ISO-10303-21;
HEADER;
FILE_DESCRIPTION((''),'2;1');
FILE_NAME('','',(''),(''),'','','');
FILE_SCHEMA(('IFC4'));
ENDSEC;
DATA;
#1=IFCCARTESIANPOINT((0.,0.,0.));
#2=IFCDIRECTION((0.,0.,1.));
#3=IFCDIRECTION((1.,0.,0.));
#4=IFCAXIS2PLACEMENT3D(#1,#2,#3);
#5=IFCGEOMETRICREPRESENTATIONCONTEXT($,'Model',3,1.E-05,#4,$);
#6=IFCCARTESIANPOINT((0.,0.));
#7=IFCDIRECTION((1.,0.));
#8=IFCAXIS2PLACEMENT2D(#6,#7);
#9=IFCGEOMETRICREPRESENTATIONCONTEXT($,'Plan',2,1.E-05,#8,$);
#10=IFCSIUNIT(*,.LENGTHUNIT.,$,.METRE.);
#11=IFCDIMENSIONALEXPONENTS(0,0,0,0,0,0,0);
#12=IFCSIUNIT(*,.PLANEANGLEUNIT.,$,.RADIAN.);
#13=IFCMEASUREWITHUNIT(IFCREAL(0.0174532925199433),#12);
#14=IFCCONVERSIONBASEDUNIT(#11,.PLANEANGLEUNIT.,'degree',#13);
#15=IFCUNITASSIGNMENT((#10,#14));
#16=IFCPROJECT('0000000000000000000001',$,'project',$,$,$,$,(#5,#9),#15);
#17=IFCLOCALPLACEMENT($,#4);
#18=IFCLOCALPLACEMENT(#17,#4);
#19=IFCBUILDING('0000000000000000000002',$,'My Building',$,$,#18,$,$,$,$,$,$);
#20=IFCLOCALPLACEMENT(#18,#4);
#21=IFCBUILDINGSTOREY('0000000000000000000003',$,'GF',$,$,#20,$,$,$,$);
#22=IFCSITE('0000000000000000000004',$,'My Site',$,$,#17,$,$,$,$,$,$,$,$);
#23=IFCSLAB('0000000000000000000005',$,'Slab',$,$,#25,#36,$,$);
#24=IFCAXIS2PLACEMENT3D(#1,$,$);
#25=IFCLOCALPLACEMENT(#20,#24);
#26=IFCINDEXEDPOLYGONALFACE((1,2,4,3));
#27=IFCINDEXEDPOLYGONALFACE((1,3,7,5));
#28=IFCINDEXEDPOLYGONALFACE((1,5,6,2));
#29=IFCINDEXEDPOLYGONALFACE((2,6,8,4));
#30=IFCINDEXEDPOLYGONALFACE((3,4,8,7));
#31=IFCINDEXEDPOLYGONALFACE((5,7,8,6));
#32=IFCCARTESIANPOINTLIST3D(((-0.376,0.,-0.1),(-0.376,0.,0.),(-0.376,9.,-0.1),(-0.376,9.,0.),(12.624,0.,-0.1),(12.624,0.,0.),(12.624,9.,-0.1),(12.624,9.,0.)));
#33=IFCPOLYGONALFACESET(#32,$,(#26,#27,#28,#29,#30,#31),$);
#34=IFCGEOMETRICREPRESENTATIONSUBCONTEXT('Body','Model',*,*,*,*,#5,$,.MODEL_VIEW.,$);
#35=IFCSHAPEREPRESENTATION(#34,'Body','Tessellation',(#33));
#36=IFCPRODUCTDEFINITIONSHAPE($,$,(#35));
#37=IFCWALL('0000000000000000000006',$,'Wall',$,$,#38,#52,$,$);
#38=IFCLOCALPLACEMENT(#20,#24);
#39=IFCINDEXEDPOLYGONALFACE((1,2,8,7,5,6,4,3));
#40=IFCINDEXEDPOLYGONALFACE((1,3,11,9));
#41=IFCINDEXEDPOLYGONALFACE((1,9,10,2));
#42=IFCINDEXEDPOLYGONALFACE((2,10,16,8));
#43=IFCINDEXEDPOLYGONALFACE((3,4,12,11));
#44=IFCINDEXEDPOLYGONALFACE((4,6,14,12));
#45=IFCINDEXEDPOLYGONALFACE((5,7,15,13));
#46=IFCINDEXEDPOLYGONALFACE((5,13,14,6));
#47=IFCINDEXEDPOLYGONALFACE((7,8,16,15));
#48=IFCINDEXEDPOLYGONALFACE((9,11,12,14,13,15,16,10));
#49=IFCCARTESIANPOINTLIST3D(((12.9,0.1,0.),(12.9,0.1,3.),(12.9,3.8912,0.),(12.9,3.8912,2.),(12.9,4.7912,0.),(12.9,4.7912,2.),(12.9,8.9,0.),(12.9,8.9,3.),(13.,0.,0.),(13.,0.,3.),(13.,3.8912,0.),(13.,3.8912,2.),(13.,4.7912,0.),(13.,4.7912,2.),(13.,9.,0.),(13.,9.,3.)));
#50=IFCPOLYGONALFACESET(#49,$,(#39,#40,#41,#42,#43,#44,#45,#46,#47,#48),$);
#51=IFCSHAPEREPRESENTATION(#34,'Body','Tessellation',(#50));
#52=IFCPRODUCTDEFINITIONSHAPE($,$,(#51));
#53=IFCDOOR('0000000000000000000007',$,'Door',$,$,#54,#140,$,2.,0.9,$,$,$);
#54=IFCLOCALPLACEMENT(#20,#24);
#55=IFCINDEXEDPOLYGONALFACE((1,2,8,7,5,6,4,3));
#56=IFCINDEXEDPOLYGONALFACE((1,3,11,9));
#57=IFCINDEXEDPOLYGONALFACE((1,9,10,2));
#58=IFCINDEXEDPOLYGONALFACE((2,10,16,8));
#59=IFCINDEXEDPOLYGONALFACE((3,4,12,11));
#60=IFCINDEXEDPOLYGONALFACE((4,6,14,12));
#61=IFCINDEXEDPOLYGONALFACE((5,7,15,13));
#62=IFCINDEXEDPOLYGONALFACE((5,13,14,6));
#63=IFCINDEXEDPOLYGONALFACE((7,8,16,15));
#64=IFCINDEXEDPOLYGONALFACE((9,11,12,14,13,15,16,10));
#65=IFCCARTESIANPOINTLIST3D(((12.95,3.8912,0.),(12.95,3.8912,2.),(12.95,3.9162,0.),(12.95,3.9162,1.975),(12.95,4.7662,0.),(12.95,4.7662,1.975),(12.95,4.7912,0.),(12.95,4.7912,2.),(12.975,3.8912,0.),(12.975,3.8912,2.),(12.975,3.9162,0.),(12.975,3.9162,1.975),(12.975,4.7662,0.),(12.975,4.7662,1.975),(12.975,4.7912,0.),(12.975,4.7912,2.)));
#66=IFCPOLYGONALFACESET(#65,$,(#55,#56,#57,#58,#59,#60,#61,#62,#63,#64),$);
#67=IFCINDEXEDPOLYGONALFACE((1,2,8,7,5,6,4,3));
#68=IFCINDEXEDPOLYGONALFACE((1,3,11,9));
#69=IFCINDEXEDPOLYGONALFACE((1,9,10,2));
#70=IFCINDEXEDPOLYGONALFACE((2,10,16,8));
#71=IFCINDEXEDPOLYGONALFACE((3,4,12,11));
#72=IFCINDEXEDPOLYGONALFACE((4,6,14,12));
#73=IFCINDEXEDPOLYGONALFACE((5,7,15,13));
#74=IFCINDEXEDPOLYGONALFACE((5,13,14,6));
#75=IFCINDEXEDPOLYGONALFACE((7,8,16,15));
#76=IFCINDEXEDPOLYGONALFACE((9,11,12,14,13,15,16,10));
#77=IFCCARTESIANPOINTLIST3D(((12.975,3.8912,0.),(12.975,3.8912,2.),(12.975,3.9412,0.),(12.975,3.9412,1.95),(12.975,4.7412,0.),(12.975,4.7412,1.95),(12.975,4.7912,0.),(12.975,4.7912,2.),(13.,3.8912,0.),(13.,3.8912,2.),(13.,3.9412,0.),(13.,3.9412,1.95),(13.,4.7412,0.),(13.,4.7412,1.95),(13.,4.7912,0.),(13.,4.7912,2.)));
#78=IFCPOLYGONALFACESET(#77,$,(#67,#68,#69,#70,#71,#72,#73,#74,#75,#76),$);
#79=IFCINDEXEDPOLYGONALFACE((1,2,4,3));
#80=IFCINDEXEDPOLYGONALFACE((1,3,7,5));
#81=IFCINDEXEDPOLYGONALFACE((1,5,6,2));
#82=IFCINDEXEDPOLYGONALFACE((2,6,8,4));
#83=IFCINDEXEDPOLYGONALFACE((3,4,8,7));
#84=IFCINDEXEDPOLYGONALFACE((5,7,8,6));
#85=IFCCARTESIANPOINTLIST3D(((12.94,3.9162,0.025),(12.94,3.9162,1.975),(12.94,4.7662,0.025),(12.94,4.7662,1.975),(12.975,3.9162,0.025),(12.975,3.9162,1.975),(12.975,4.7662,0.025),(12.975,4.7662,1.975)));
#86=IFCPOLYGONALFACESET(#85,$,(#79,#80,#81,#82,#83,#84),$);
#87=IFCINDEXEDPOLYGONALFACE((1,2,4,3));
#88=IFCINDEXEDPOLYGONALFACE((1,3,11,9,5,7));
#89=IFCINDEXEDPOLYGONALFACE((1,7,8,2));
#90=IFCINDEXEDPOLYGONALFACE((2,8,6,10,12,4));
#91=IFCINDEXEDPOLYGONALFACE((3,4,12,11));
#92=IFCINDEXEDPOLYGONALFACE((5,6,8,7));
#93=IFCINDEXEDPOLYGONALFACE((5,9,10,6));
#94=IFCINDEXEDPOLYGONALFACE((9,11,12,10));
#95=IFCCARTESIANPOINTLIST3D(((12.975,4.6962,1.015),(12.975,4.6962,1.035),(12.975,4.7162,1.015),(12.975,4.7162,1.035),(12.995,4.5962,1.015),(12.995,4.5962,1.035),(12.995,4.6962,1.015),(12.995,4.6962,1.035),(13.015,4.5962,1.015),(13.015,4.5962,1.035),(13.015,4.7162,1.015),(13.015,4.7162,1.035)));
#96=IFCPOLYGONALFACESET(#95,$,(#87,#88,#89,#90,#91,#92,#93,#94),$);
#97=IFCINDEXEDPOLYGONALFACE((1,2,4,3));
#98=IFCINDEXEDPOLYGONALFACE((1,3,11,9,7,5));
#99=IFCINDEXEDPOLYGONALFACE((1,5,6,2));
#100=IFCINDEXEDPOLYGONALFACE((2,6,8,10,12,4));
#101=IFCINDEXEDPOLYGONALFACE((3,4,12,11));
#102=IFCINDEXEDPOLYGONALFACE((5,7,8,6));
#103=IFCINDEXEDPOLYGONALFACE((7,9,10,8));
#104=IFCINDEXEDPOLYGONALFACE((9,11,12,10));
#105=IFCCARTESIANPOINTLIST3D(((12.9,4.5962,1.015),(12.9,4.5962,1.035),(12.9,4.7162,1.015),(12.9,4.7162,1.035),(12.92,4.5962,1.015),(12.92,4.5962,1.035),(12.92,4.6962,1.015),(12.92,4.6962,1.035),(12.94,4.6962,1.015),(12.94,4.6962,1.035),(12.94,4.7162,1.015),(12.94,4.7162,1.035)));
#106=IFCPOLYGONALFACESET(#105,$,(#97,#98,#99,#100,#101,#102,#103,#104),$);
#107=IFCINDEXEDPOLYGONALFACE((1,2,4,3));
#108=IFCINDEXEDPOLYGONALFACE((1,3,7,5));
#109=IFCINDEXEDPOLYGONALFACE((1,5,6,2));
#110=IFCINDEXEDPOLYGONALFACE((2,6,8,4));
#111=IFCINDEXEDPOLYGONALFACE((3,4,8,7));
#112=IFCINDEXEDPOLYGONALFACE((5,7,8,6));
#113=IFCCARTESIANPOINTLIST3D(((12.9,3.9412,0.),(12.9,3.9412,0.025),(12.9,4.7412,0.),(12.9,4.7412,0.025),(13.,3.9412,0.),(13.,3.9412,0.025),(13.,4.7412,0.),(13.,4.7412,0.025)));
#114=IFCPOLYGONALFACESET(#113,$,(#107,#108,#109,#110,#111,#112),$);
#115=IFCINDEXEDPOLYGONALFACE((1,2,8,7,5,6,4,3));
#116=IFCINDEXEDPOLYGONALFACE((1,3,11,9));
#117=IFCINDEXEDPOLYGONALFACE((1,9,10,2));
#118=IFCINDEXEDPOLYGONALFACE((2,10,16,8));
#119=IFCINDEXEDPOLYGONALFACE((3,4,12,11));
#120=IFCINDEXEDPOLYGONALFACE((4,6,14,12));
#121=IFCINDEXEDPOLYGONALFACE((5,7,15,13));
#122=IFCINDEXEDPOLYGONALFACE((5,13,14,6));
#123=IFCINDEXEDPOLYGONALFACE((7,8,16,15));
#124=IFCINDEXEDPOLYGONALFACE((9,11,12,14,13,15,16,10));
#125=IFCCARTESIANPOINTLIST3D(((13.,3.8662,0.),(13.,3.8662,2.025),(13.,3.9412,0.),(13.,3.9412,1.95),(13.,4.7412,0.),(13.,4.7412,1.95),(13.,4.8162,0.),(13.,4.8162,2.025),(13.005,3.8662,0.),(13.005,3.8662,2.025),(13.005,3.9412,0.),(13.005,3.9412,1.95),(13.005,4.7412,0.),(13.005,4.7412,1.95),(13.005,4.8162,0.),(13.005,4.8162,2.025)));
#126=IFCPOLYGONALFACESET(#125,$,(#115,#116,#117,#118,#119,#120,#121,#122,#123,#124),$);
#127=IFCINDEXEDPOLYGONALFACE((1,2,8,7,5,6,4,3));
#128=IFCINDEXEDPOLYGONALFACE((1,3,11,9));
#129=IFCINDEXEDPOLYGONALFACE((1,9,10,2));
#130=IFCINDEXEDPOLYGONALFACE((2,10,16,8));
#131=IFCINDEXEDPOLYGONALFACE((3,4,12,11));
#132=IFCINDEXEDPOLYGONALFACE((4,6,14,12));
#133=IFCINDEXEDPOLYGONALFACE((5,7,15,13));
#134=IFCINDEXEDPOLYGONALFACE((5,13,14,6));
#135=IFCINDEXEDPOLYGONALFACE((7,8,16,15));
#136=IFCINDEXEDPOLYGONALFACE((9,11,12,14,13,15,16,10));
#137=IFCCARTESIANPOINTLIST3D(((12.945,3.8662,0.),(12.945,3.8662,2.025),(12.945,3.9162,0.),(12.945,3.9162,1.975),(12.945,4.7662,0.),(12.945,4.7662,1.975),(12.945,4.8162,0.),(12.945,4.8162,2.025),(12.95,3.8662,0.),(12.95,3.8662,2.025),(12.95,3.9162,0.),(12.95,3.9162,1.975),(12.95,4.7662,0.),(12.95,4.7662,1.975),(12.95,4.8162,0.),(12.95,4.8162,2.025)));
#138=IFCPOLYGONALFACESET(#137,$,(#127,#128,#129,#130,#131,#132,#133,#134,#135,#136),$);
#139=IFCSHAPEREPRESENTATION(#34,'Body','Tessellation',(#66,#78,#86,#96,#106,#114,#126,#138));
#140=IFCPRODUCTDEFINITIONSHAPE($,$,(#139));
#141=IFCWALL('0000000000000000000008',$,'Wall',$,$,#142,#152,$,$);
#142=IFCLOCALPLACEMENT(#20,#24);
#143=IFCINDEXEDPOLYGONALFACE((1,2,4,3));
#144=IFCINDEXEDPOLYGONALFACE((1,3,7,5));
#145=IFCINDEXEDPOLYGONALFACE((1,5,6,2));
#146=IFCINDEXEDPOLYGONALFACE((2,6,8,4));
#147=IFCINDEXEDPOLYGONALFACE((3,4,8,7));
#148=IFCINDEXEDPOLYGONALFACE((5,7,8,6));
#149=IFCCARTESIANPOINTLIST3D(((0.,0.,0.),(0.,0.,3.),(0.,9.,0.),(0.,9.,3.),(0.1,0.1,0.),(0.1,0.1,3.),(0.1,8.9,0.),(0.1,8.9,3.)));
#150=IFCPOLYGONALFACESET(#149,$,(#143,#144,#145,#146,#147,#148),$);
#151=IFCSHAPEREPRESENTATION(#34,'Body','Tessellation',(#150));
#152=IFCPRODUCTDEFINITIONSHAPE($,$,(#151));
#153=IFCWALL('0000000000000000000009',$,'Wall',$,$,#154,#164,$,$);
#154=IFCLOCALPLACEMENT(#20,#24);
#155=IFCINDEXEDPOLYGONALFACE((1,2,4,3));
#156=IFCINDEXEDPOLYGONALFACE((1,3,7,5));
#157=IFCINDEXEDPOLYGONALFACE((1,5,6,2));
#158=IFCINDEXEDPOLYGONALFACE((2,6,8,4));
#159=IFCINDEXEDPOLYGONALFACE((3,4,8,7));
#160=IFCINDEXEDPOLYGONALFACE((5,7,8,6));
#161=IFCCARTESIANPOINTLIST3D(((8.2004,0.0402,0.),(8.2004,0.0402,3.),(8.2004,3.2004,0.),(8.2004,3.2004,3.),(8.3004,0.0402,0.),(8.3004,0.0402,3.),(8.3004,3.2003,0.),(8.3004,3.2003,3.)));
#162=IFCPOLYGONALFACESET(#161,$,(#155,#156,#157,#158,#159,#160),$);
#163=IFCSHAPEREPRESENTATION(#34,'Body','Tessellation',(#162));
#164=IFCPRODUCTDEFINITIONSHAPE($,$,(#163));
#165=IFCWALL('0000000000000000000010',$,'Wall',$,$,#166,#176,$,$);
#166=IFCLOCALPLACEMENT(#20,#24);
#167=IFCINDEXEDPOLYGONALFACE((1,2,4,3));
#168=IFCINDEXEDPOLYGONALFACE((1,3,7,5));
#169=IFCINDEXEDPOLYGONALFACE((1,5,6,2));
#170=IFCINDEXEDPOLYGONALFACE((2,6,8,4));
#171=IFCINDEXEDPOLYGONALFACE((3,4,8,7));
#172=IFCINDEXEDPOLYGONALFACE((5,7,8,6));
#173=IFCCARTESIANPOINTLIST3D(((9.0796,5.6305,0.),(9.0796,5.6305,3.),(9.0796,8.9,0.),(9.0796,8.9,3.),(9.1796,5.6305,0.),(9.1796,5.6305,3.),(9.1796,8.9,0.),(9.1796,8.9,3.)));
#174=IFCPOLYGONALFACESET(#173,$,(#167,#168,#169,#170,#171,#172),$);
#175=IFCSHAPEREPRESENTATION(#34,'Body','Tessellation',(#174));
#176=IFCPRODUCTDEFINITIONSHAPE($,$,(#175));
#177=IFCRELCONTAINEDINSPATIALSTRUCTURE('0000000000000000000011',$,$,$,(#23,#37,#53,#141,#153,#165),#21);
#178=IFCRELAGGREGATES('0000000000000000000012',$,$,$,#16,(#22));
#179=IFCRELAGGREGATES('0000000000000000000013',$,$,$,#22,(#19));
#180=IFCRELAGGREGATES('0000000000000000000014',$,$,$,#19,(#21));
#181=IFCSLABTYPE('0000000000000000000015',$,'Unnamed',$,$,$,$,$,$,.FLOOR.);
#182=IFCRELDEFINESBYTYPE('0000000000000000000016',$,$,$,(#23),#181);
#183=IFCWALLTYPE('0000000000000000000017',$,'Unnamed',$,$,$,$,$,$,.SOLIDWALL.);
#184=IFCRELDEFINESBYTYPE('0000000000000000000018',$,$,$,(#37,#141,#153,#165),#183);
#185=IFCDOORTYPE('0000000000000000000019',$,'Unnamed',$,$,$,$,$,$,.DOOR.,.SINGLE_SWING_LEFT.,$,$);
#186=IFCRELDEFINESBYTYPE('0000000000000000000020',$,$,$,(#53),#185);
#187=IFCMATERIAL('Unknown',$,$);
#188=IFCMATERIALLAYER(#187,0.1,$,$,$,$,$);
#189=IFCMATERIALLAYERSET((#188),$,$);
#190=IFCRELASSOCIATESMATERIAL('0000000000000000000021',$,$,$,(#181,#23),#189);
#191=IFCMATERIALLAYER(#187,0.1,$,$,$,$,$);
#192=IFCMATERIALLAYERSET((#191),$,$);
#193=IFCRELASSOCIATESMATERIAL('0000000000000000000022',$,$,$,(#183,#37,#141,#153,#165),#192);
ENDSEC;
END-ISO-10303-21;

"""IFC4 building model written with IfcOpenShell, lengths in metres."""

from ifc_helpers import new_model, entity, si_unit, converted_unit, frame, origin_with_axes, origin_2d_with_axis, place, context, subcontext, project, spatial, line, indexed_curve, outline, extrude, shape, source, transform, mapped, material, layer, layer_set, layer_usage, type_object, type_shapes, element, fill, save


model = new_model("IFC4")

# Units and contexts
model_context = context("Model", 3, precision=1e-05, world=origin_with_axes())
plan_context = context("Plan", 2, precision=1e-05, world=origin_2d_with_axis())
body_context_1 = subcontext(model_context, "Body", "Model", "MODEL_VIEW")
body_context_2 = subcontext(plan_context, "Body", "Plan", "PLAN_VIEW")
ifc_project = project(units=[si_unit("LENGTHUNIT", "METRE"), converted_unit("PLANEANGLEUNIT", "degree", entity("IfcReal", 0.0174532925199433), si_unit("PLANEANGLEUNIT", "RADIAN"), dimensions=[0, 0, 0, 0, 0, 0, 0])], contexts=[model_context, plan_context])

# Site, building, storey
site_placement = place(None, origin_with_axes())
site = spatial("IfcSite", under=ifc_project, at=site_placement, Name="My Site")
building_placement = place(site_placement, origin_with_axes())
building = spatial("IfcBuilding", under=site, at=building_placement, Name="My Building")
storey_placement = place(building_placement, origin_with_axes())
storey = spatial("IfcBuildingStorey", under=building, at=storey_placement, Name="GF")

# Slab
ifc_material = material(Name="Unknown")
ifc_layer_1 = layer(ifc_material, 0.1)
ifc_layer_set_1 = layer_set([ifc_layer_1])
ifc_layer_usage_1 = layer_usage(ifc_layer_set_1, "AXIS3", "POSITIVE", -0.1)
slab_type = type_object("IfcSlabType", Name="Unnamed", PredefinedType="FLOOR", material=ifc_layer_set_1)
slab_placement = place(storey_placement, frame((-0.376, 9.0, 0.0), z_axis=(0.0, 0.0, 1.0), x_axis=(1.0, 0.0, 0.0)))
element("IfcSlab", 1, at=slab_placement, inside=storey, type_object=slab_type, material=ifc_layer_usage_1, Name="Slab", context=body_context_1, shape_type="SweptSolid", body=[
    extrude(outline(indexed_curve([(0.0, -9.0), (13.0, -9.0), (13.0, 0.0), (0.0, 0.0), (0.0, -9.0)])), frame((0.0, 0.0, -0.1), z_axis=(0.0, 0.0, 1.0), x_axis=(1.0, 0.0, 0.0)), (0.0, 0.0, 1.0), 0.1),
])

# Shared definitions
ifc_layer_2 = layer(ifc_material, 0.1)
ifc_layer_set_2 = layer_set([ifc_layer_2])
wall_type = type_object("IfcWallType", Name="Unnamed", PredefinedType="SOLIDWALL", material=ifc_layer_set_2)
shared_shape_1 = source(origin_with_axes(), body_context_1, "Body", "SweptSolid", [
    extrude(outline(indexed_curve([(0.0, 0.0), (0.9, 0.0), (0.9, 2.0), (0.0, 2.0)], segments=[line(1, 2, 3, 4, 1)])), frame((0.0, -0.6, 0.0), z_axis=(0.0, -1.0, 0.0), x_axis=(1.0, 0.0, 0.0)), (0.0, 0.0, -1.0), 1.2),
])
door_type = type_object("IfcDoorType", Name="Unnamed", OperationType="SINGLE_SWING_LEFT", PredefinedType="DOOR")
shared_shape_2 = source(origin_with_axes(), body_context_1, "Body", "SweptSolid", [
    extrude(outline(indexed_curve([(0.0, 0.0), (0.0, 2.0), (0.9, 2.0), (0.9, 0.0), (0.875, 0.0), (0.875, 1.975), (0.025, 1.975), (0.025, 0.0)], segments=[line(1, 2, 3, 4, 5, 6, 7, 8, 1)])), frame((0.0, 0.025, 0.0), z_axis=(0.0, -1.0, 0.0), x_axis=(1.0, 0.0, 0.0)), (0.0, 0.0, -1.0), 0.025),
    extrude(outline(indexed_curve([(0.0, 0.0), (0.0, 2.0), (0.9, 2.0), (0.9, 0.0), (0.85, 0.0), (0.85, 1.95), (0.05, 1.95), (0.05, 0.0)], segments=[line(1, 2, 3, 4, 5, 6, 7, 8, 1)])), frame((0.0, 0.0, 0.0), z_axis=(0.0, -1.0, 0.0), x_axis=(1.0, 0.0, 0.0)), (0.0, 0.0, -1.0), 0.025),
    extrude(outline(indexed_curve([(0.0, 0.0), (0.85, 0.0), (0.85, 0.035), (0.0, 0.035)], segments=[line(1, 2, 3, 4, 1)])), frame((0.025, 0.025, 0.025), z_axis=(0.0, 0.0, 1.0), x_axis=(1.0, 0.0, 0.0)), (0.0, 0.0, 1.0), 1.95),
    extrude(outline(indexed_curve([(0.0, 0.0), (0.0, -0.04), (-0.12, -0.04), (-0.12, -0.02), (-0.02, -0.02), (-0.02, 0.0)], segments=[line(1, 2, 3, 4, 5, 6, 1)])), frame((0.825, 0.025, 1.015), z_axis=(0.0, 0.0, 1.0), x_axis=(1.0, 0.0, 0.0)), (0.0, 0.0, 1.0), 0.02),
    extrude(outline(indexed_curve([(0.0, 0.0), (0.0, 0.04), (-0.12, 0.04), (-0.12, 0.02), (-0.02, 0.02), (-0.02, 0.0)], segments=[line(1, 2, 3, 4, 5, 6, 1)])), frame((0.825, 0.06, 1.015), z_axis=(0.0, 0.0, 1.0), x_axis=(1.0, 0.0, 0.0)), (0.0, 0.0, 1.0), 0.02),
    extrude(outline(indexed_curve([(0.0, 0.0), (0.8, 0.0), (0.8, 0.1), (0.0, 0.1)], segments=[line(1, 2, 3, 4, 1)])), frame((0.05, 0.0, 0.0), z_axis=(0.0, 0.0, 1.0), x_axis=(1.0, 0.0, 0.0)), (0.0, 0.0, 1.0), 0.025),
    extrude(outline(indexed_curve([(0.0, 0.0), (0.0, 2.025), (0.95, 2.025), (0.95, 0.0), (0.875, 0.0), (0.875, 1.95), (0.075, 1.95), (0.075, 0.0)], segments=[line(1, 2, 3, 4, 5, 6, 7, 8, 1)])), frame((-0.025, -0.005, 0.0), z_axis=(0.0, -1.0, 0.0), x_axis=(1.0, 0.0, 0.0)), (0.0, 0.0, -1.0), 0.005),
    extrude(outline(indexed_curve([(0.0, 0.0), (0.0, 2.025), (0.95, 2.025), (0.95, 0.0), (0.9, 0.0), (0.9, 1.975), (0.05, 1.975), (0.05, 0.0)], segments=[line(1, 2, 3, 4, 5, 6, 7, 8, 1)])), frame((-0.025, 0.05, 0.0), z_axis=(0.0, -1.0, 0.0), x_axis=(1.0, 0.0, 0.0)), (0.0, 0.0, -1.0), 0.005),
])
shared_shape_3 = source(origin_with_axes(), body_context_2, "Body", "Curve2D", [
    entity("IfcIndexedPolyCurve", entity("IfcCartesianPointList2D", [[0.0, 0.0], [0.0, 0.05], [0.025, 0.05], [0.025, 0.025], [0.05, 0.025], [0.05, 0.0]]), [entity("IfcLineIndex", [1, 2, 3, 4, 5, 6, 1])]),
    entity("IfcIndexedPolyCurve", entity("IfcCartesianPointList2D", [[0.9, 0.0], [0.9, 0.05], [0.875, 0.05], [0.875, 0.025], [0.85, 0.025], [0.85, 0.0]]), [entity("IfcLineIndex", [1, 2, 3, 4, 5, 6, 1])]),
    entity("IfcTrimmedCurve", entity("IfcEllipse", entity("IfcAxis2Placement2D", entity("IfcCartesianPoint", [0.06, 0.05]), entity("IfcDirection", [1.0, 0.0])), 0.815, 0.85), [entity("IfcCartesianPoint", [0.875, 0.05])], [entity("IfcCartesianPoint", [0.06, 0.9])], True, "CARTESIAN"),
    entity("IfcIndexedPolyCurve", entity("IfcCartesianPointList2D", [[0.025, 0.05], [0.06, 0.05], [0.06, 0.9], [0.025, 0.9]]), [entity("IfcLineIndex", [1, 2, 3, 4, 1])]),
])
type_shapes(door_type, [shared_shape_2, shared_shape_3])

# Wall, opening, door
ifc_layer_usage_2 = layer_usage(ifc_layer_set_2, "AXIS2", "POSITIVE", 0.0)
wall_1_placement = place(storey_placement, frame((13.0, 0.0, 0.0), z_axis=(0.0, 0.0, 1.0), x_axis=(0.0, 1.0, 0.0)))
wall_1 = element("IfcWall", 2, at=wall_1_placement, inside=storey, type_object=wall_type, material=ifc_layer_usage_2, Name="Wall", context=body_context_1, shape_type="SweptSolid", body=[
    extrude(outline(indexed_curve([(0.0, 0.0), (0.1, 0.1), (8.9, 0.1), (9.0, 0.0)], segments=[line(1, 2, 3, 4, 1)])), origin_with_axes(), (0.0, 0.0, 1.0), 3.0),
])
opening_1_placement = place(wall_1_placement, frame((3.8912, 0.0, 0.0), z_axis=(0.0, 0.0, 1.0), x_axis=(1.0, 0.0, 0.0)))
opening_1 = element("IfcOpeningElement", 3, at=opening_1_placement, cuts=wall_1, PredefinedType="OPENING", context=body_context_1, shape_type="MappedRepresentation", body=[
    mapped(shared_shape_1, transform((0.0, 0.0, 0.0), x_axis=(1.0, 0.0, 0.0), y_axis=(0.0, 1.0, 0.0), z_axis=(0.0, 0.0, 1.0), scale=1.0)),
])
door_1_placement = place(opening_1_placement, frame((0.0, 0.0, 0.0), z_axis=(0.0, 0.0, 1.0), x_axis=(1.0, 0.0, 0.0)))
door_1 = element("IfcDoor", 4, at=door_1_placement, inside=storey, type_object=door_type, Name="Door", OverallHeight=2.0, OverallWidth=0.9, shapes=[
    shape(body_context_1, "Body", "MappedRepresentation", [mapped(shared_shape_2, transform((0.0, 0.0, 0.0), x_axis=(1.0, 0.0, 0.0), y_axis=(0.0, 1.0, 0.0), z_axis=(0.0, 0.0, 1.0), scale=1.0))]),
    shape(body_context_2, "Body", "MappedRepresentation", [mapped(shared_shape_3, transform((0.0, 0.0, 0.0), x_axis=(1.0, 0.0, 0.0), y_axis=(0.0, 1.0, 0.0), z_axis=(0.0, 0.0, 1.0), scale=1.0))]),
])
fill(opening_1, door_1)

# Wall
ifc_layer_usage_3 = layer_usage(ifc_layer_set_2, "AXIS2", "POSITIVE", 0.0)
wall_2_placement = place(storey_placement, frame((0.0, 9.0, 0.0), z_axis=(0.0, 0.0, 1.0), x_axis=(0.0, -1.0, 0.0)))
element("IfcWall", 5, at=wall_2_placement, inside=storey, type_object=wall_type, material=ifc_layer_usage_3, Name="Wall", context=body_context_1, shape_type="SweptSolid", body=[
    extrude(outline(indexed_curve([(0.0, 0.0), (0.1, 0.1), (8.9, 0.1), (9.0, 0.0)], segments=[line(1, 2, 3, 4, 1)])), origin_with_axes(), (0.0, 0.0, 1.0), 3.0),
])

# Walls
ifc_layer_usage_4 = layer_usage(ifc_layer_set_2, "AXIS2", "POSITIVE", 0.0)
wall_3_placement = place(storey_placement, frame((8.3004, 0.0402, 0.0), z_axis=(0.0, 0.0, 1.0), x_axis=(0.000013, 1.0, 0.0)))
element("IfcWall", 6, at=wall_3_placement, inside=storey, type_object=wall_type, material=ifc_layer_usage_4, Name="Wall", context=body_context_1, shape_type="SweptSolid", body=[
    extrude(outline(indexed_curve([(0.0, 0.0), (0.0, 0.1), (3.1602, 0.1), (3.1602, 0.0)], segments=[line(1, 2, 3, 4, 1)])), origin_with_axes(), (0.0, 0.0, 1.0), 3.0),
])
ifc_layer_usage_5 = layer_usage(ifc_layer_set_2, "AXIS2", "POSITIVE", 0.0)
wall_4_placement = place(storey_placement, frame((9.1796, 5.6305, 0.0), z_axis=(0.0, 0.0, 1.0), x_axis=(0.0, 1.0, 0.0)))
element("IfcWall", 7, at=wall_4_placement, inside=storey, type_object=wall_type, material=ifc_layer_usage_5, Name="Wall", context=body_context_1, shape_type="SweptSolid", body=[
    extrude(outline(indexed_curve([(0.0, 0.0), (0.0, 0.1), (3.2695, 0.1), (3.2695, 0.0)], segments=[line(1, 2, 3, 4, 1)])), origin_with_axes(), (0.0, 0.0, 1.0), 3.0),
])

save(model, "model.ifc")
